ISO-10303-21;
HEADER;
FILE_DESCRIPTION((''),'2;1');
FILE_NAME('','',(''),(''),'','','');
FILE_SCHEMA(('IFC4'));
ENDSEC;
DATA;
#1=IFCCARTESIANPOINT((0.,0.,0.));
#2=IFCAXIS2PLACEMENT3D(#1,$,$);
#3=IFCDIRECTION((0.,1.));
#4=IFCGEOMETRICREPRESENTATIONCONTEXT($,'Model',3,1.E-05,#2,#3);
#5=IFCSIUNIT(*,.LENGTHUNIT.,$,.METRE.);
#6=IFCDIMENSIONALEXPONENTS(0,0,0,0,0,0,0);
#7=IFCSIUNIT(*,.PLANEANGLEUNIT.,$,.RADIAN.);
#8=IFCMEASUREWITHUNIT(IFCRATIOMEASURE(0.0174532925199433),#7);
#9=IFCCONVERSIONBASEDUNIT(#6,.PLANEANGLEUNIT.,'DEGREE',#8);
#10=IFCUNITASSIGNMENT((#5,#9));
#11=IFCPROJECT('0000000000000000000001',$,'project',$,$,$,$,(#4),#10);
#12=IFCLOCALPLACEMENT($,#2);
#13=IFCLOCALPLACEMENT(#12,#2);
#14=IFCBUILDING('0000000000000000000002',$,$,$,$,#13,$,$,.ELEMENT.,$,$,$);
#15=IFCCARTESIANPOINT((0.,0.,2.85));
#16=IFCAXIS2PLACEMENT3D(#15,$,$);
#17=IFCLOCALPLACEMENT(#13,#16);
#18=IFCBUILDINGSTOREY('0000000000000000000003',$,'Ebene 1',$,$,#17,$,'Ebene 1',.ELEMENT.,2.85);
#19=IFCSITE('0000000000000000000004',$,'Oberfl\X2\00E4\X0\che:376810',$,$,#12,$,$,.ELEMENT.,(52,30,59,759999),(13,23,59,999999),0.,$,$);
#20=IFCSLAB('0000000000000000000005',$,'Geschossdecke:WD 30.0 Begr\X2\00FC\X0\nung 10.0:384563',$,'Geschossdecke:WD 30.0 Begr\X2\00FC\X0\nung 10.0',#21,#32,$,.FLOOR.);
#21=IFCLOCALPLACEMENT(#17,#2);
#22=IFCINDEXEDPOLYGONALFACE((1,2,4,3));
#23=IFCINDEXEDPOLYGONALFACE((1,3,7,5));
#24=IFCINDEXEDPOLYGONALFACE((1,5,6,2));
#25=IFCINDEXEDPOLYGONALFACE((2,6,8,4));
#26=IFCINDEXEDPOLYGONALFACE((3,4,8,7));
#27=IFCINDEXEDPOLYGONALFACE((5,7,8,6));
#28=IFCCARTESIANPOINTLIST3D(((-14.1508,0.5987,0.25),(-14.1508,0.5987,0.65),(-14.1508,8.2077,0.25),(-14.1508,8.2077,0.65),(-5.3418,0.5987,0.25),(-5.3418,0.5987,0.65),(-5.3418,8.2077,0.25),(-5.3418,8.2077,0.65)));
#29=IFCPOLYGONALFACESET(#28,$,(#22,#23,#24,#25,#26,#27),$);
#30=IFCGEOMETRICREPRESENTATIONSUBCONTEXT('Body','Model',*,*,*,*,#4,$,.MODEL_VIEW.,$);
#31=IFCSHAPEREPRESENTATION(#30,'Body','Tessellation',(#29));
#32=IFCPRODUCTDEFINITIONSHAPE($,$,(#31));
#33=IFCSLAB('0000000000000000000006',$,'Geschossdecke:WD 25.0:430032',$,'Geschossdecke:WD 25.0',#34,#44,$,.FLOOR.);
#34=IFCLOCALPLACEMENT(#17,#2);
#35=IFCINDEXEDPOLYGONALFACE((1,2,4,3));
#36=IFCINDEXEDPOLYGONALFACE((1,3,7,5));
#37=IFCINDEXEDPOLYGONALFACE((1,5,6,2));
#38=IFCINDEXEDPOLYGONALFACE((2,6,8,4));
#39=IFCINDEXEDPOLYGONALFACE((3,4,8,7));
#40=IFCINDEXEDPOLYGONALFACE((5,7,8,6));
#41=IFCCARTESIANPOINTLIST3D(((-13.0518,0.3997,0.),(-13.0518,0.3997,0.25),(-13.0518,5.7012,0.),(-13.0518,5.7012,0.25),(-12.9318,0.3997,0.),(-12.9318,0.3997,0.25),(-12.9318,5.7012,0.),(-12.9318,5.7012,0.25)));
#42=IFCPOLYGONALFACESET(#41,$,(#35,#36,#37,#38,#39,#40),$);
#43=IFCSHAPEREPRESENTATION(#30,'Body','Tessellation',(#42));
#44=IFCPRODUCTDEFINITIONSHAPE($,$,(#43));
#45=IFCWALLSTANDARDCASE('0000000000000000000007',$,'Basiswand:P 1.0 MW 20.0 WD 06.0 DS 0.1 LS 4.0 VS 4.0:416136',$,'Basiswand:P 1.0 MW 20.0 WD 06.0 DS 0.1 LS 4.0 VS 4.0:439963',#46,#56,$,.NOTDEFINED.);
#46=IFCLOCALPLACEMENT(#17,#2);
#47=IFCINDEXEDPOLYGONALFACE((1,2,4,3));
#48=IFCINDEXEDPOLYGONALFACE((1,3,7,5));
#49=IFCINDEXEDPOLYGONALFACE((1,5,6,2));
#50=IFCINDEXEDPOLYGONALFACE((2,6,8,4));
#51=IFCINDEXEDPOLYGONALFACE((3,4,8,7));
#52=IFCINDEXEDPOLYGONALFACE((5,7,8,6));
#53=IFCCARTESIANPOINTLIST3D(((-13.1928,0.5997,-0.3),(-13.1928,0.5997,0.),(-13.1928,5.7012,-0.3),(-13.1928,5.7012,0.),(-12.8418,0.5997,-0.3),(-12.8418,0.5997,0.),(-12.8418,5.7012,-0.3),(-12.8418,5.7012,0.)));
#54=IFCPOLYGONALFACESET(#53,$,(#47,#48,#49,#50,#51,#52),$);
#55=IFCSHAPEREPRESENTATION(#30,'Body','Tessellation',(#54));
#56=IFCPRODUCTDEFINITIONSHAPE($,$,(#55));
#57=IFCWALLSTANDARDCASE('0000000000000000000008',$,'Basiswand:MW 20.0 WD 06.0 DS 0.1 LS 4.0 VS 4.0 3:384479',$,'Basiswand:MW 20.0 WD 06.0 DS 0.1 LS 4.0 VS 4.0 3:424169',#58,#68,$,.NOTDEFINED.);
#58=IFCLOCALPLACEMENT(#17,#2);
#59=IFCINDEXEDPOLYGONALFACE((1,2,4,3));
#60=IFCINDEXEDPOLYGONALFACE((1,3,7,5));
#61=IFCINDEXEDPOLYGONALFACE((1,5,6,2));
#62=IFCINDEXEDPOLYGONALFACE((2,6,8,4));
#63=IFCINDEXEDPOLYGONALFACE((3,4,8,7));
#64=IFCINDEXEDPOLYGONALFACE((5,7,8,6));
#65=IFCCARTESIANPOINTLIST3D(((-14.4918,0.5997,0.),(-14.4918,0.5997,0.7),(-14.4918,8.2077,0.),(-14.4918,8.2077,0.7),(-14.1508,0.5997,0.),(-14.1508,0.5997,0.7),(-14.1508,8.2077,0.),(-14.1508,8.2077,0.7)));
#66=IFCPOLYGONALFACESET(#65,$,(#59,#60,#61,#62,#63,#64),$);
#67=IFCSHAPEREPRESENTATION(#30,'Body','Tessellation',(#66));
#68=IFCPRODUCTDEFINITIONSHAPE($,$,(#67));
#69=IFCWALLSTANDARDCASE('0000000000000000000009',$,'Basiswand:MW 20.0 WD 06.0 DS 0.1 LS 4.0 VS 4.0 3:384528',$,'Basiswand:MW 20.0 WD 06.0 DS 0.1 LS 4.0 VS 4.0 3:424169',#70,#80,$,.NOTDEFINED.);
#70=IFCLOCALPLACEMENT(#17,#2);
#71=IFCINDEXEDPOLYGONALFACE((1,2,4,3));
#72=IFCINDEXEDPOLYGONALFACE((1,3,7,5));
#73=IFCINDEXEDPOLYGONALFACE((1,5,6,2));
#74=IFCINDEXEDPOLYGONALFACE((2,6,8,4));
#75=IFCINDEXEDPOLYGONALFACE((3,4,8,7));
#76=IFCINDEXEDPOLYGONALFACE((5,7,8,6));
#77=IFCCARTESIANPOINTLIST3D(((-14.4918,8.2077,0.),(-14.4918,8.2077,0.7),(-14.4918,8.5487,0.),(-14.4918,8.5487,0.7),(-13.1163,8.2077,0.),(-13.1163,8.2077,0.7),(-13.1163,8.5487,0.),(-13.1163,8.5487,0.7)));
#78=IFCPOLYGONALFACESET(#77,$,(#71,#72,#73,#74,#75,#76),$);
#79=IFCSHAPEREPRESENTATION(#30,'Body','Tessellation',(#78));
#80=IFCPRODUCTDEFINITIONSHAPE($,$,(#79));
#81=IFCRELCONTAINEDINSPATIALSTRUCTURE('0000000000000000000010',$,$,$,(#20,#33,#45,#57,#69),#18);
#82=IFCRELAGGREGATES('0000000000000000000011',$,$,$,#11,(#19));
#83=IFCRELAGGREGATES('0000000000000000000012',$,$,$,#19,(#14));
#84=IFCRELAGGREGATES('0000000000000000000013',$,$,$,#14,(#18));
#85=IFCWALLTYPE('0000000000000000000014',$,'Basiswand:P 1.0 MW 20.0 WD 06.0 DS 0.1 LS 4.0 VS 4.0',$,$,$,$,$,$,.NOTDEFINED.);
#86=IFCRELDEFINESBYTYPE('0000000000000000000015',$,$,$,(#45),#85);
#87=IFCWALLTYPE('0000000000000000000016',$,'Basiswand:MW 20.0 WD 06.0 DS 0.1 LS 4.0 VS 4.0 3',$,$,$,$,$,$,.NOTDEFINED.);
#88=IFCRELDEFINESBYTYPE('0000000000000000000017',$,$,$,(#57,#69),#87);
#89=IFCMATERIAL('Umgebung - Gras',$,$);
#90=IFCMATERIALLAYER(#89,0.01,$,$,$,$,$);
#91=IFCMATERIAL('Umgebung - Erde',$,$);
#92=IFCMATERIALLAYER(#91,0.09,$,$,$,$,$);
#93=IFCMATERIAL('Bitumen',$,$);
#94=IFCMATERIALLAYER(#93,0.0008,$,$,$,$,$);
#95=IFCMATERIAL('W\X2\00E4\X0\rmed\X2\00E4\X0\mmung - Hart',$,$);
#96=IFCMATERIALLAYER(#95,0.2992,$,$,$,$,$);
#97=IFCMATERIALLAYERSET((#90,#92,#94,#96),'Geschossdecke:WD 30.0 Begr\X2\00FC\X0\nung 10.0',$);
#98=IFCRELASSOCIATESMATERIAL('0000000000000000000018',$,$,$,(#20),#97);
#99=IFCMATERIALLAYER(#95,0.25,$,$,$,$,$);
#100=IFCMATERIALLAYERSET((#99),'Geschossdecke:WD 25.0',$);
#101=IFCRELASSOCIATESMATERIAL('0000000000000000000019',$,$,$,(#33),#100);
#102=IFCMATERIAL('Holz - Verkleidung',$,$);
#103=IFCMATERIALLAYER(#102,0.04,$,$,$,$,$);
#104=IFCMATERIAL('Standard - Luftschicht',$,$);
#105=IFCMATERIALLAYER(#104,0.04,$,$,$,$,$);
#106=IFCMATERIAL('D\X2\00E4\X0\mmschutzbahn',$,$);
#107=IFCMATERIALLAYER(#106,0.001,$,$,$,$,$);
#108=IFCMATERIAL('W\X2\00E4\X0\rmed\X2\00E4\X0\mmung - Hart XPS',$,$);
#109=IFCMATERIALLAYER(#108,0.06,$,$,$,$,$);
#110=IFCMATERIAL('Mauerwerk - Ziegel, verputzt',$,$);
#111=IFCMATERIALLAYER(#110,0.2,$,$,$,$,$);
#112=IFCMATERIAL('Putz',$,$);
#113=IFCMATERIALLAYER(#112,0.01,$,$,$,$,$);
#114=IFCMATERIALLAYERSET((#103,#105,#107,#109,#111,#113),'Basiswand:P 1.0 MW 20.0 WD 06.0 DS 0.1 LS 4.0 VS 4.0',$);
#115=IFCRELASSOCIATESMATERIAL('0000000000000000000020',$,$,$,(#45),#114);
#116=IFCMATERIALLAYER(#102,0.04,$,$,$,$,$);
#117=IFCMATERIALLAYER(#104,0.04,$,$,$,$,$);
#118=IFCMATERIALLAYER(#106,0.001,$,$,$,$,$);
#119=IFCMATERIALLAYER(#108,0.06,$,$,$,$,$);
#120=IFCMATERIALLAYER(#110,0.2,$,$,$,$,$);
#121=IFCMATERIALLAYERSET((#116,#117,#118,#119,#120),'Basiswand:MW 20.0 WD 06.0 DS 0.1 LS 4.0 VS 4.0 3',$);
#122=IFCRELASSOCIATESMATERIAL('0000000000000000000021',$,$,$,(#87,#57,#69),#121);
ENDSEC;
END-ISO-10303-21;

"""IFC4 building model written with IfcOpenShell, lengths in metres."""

from ifc_helpers import new_model, entity, si_unit, converted_unit, direction, frame, frame_2d, origin, place, context, subcontext, project, spatial, rectangle, extrude, material, layer, layer_set, layer_usage, type_object, element, save


model = new_model("IFC4")

# Units and contexts
model_context = context("Model", 3, precision=1e-05, world=origin(), true_north=direction((0.0, 1.0)))
body_context = subcontext(model_context, "Body", "Model", "MODEL_VIEW")
ifc_project = project(units=[si_unit("LENGTHUNIT", "METRE"), converted_unit("PLANEANGLEUNIT", "DEGREE", entity("IfcRatioMeasure", 0.0174532925199433), si_unit("PLANEANGLEUNIT", "RADIAN"), dimensions=[0, 0, 0, 0, 0, 0, 0])], contexts=[model_context])

# Site, building, storey
site_placement = place(None, origin())
site = spatial("IfcSite", under=ifc_project, at=site_placement, Name="Oberfläche:376810", CompositionType="ELEMENT", RefLatitude=(52, 30, 59, 759999), RefLongitude=(13, 23, 59, 999999), RefElevation=0.0)
building_placement = place(site_placement, origin())
building = spatial("IfcBuilding", under=site, at=building_placement, CompositionType="ELEMENT")
storey_placement = place(building_placement, frame((0.0, 0.0, 2.85)))
storey = spatial("IfcBuildingStorey", under=building, at=storey_placement, Name="Ebene 1", LongName="Ebene 1", CompositionType="ELEMENT", Elevation=2.85)

# Slabs
ifc_material_1 = material(Name="Umgebung - Gras")
ifc_layer_1 = layer(ifc_material_1, 0.01)
ifc_material_2 = material(Name="Umgebung - Erde")
ifc_layer_2 = layer(ifc_material_2, 0.09)
ifc_material_3 = material(Name="Bitumen")
ifc_layer_3 = layer(ifc_material_3, 0.0008)
ifc_material_4 = material(Name="Wärmedämmung - Hart")
ifc_layer_4 = layer(ifc_material_4, 0.2992)
ifc_layer_set_1 = layer_set([ifc_layer_1, ifc_layer_2, ifc_layer_3, ifc_layer_4], Name="Geschossdecke:WD 30.0 Begrünung 10.0")
ifc_layer_usage_1 = layer_usage(ifc_layer_set_1, "AXIS3", "POSITIVE", 0.0)
slab_1_placement = place(storey_placement, origin())
element("IfcSlab", 1, at=slab_1_placement, inside=storey, material=ifc_layer_usage_1, Name="Geschossdecke:WD 30.0 Begrünung 10.0:384563", ObjectType="Geschossdecke:WD 30.0 Begrünung 10.0", PredefinedType="FLOOR", context=body_context, shape_type="SweptSolid", body=[
    extrude(rectangle(XDim=7.609, YDim=8.809, at=frame_2d((0.0, 0.0), x_axis=(1.0, 0.0))), frame((-9.7463, 4.4032, 0.65), z_axis=(0.0, 0.0, -1.0), x_axis=(0.0, 1.0, 0.0)), (0.0, 0.0, 1.0), 0.4),
])
ifc_layer_5 = layer(ifc_material_4, 0.25)
ifc_layer_set_2 = layer_set([ifc_layer_5], Name="Geschossdecke:WD 25.0")
ifc_layer_usage_2 = layer_usage(ifc_layer_set_2, "AXIS3", "POSITIVE", 0.0)
slab_2_placement = place(storey_placement, origin())
element("IfcSlab", 2, at=slab_2_placement, inside=storey, material=ifc_layer_usage_2, Name="Geschossdecke:WD 25.0:430032", ObjectType="Geschossdecke:WD 25.0", PredefinedType="FLOOR", context=body_context, shape_type="SweptSolid", body=[
    extrude(rectangle(XDim=5.3015, YDim=0.12, at=frame_2d((0.0, 0.0), x_axis=(1.0, 0.0))), frame((-12.9918, 3.0505, 0.25), z_axis=(0.0, 0.0, -1.0), x_axis=(0.0, 1.0, 0.0)), (0.0, 0.0, 1.0), 0.25),
])

# Walls
ifc_material_5 = material(Name="Holz - Verkleidung")
ifc_layer_6 = layer(ifc_material_5, 0.04)
ifc_material_6 = material(Name="Standard - Luftschicht")
ifc_layer_7 = layer(ifc_material_6, 0.04)
ifc_material_7 = material(Name="Dämmschutzbahn")
ifc_layer_8 = layer(ifc_material_7, 0.001)
ifc_material_8 = material(Name="Wärmedämmung - Hart XPS")
ifc_layer_9 = layer(ifc_material_8, 0.06)
ifc_material_9 = material(Name="Mauerwerk - Ziegel, verputzt")
ifc_layer_10 = layer(ifc_material_9, 0.2)
ifc_material_10 = material(Name="Putz")
ifc_layer_11 = layer(ifc_material_10, 0.01)
ifc_layer_set_3 = layer_set([ifc_layer_6, ifc_layer_7, ifc_layer_8, ifc_layer_9, ifc_layer_10, ifc_layer_11], Name="Basiswand:P 1.0 MW 20.0 WD 06.0 DS 0.1 LS 4.0 VS 4.0")
ifc_layer_usage_3 = layer_usage(ifc_layer_set_3, "AXIS2", "NEGATIVE", 0.1755)
wall_type_1 = type_object("IfcWallType", Name="Basiswand:P 1.0 MW 20.0 WD 06.0 DS 0.1 LS 4.0 VS 4.0", PredefinedType="NOTDEFINED")
wall_1_placement = place(storey_placement, frame((-13.0173, 0.5997, -0.3), z_axis=(0.0, 0.0, 1.0), x_axis=(0.0, 1.0, 0.0)))
element("IfcWallStandardCase", 3, at=wall_1_placement, inside=storey, type_object=wall_type_1, material=ifc_layer_usage_3, Name="Basiswand:P 1.0 MW 20.0 WD 06.0 DS 0.1 LS 4.0 VS 4.0:416136", ObjectType="Basiswand:P 1.0 MW 20.0 WD 06.0 DS 0.1 LS 4.0 VS 4.0:439963", PredefinedType="NOTDEFINED", context=body_context, shape_type="SweptSolid", body=[
    extrude(rectangle(XDim=5.1015, YDim=0.351, at=frame_2d((2.5508, 0.0), x_axis=(-1.0, 0.0))), origin(), (0.0, 0.0, 1.0), 0.3),
])
ifc_layer_12 = layer(ifc_material_5, 0.04)
ifc_layer_13 = layer(ifc_material_6, 0.04)
ifc_layer_14 = layer(ifc_material_7, 0.001)
ifc_layer_15 = layer(ifc_material_8, 0.06)
ifc_layer_16 = layer(ifc_material_9, 0.2)
ifc_layer_set_4 = layer_set([ifc_layer_12, ifc_layer_13, ifc_layer_14, ifc_layer_15, ifc_layer_16], Name="Basiswand:MW 20.0 WD 06.0 DS 0.1 LS 4.0 VS 4.0 3")
ifc_layer_usage_4 = layer_usage(ifc_layer_set_4, "AXIS2", "NEGATIVE", 0.1705)
wall_type_2 = type_object("IfcWallType", Name="Basiswand:MW 20.0 WD 06.0 DS 0.1 LS 4.0 VS 4.0 3", PredefinedType="NOTDEFINED", material=ifc_layer_set_4)
wall_2_placement = place(storey_placement, frame((-14.3213, 0.5997, 0.0), z_axis=(0.0, 0.0, 1.0), x_axis=(0.0, 1.0, 0.0)))
element("IfcWallStandardCase", 4, at=wall_2_placement, inside=storey, type_object=wall_type_2, material=ifc_layer_usage_4, Name="Basiswand:MW 20.0 WD 06.0 DS 0.1 LS 4.0 VS 4.0 3:384479", ObjectType="Basiswand:MW 20.0 WD 06.0 DS 0.1 LS 4.0 VS 4.0 3:424169", PredefinedType="NOTDEFINED", context=body_context, shape_type="SweptSolid", body=[
    extrude(rectangle(XDim=7.608, YDim=0.341, at=frame_2d((3.804, 0.0), x_axis=(-1.0, 0.0))), origin(), (0.0, 0.0, 1.0), 0.7),
])
ifc_layer_usage_5 = layer_usage(ifc_layer_set_4, "AXIS2", "NEGATIVE", 0.1705)
wall_3_placement = place(storey_placement, frame((-14.4918, 8.3782, 0.0)))
element("IfcWallStandardCase", 5, at=wall_3_placement, inside=storey, type_object=wall_type_2, material=ifc_layer_usage_5, Name="Basiswand:MW 20.0 WD 06.0 DS 0.1 LS 4.0 VS 4.0 3:384528", ObjectType="Basiswand:MW 20.0 WD 06.0 DS 0.1 LS 4.0 VS 4.0 3:424169", PredefinedType="NOTDEFINED", context=body_context, shape_type="SweptSolid", body=[
    extrude(rectangle(XDim=1.3755, YDim=0.341, at=frame_2d((0.6877, 0.0), x_axis=(-1.0, 0.0))), origin(), (0.0, 0.0, 1.0), 0.7),
])

save(model, "model.ifc")
